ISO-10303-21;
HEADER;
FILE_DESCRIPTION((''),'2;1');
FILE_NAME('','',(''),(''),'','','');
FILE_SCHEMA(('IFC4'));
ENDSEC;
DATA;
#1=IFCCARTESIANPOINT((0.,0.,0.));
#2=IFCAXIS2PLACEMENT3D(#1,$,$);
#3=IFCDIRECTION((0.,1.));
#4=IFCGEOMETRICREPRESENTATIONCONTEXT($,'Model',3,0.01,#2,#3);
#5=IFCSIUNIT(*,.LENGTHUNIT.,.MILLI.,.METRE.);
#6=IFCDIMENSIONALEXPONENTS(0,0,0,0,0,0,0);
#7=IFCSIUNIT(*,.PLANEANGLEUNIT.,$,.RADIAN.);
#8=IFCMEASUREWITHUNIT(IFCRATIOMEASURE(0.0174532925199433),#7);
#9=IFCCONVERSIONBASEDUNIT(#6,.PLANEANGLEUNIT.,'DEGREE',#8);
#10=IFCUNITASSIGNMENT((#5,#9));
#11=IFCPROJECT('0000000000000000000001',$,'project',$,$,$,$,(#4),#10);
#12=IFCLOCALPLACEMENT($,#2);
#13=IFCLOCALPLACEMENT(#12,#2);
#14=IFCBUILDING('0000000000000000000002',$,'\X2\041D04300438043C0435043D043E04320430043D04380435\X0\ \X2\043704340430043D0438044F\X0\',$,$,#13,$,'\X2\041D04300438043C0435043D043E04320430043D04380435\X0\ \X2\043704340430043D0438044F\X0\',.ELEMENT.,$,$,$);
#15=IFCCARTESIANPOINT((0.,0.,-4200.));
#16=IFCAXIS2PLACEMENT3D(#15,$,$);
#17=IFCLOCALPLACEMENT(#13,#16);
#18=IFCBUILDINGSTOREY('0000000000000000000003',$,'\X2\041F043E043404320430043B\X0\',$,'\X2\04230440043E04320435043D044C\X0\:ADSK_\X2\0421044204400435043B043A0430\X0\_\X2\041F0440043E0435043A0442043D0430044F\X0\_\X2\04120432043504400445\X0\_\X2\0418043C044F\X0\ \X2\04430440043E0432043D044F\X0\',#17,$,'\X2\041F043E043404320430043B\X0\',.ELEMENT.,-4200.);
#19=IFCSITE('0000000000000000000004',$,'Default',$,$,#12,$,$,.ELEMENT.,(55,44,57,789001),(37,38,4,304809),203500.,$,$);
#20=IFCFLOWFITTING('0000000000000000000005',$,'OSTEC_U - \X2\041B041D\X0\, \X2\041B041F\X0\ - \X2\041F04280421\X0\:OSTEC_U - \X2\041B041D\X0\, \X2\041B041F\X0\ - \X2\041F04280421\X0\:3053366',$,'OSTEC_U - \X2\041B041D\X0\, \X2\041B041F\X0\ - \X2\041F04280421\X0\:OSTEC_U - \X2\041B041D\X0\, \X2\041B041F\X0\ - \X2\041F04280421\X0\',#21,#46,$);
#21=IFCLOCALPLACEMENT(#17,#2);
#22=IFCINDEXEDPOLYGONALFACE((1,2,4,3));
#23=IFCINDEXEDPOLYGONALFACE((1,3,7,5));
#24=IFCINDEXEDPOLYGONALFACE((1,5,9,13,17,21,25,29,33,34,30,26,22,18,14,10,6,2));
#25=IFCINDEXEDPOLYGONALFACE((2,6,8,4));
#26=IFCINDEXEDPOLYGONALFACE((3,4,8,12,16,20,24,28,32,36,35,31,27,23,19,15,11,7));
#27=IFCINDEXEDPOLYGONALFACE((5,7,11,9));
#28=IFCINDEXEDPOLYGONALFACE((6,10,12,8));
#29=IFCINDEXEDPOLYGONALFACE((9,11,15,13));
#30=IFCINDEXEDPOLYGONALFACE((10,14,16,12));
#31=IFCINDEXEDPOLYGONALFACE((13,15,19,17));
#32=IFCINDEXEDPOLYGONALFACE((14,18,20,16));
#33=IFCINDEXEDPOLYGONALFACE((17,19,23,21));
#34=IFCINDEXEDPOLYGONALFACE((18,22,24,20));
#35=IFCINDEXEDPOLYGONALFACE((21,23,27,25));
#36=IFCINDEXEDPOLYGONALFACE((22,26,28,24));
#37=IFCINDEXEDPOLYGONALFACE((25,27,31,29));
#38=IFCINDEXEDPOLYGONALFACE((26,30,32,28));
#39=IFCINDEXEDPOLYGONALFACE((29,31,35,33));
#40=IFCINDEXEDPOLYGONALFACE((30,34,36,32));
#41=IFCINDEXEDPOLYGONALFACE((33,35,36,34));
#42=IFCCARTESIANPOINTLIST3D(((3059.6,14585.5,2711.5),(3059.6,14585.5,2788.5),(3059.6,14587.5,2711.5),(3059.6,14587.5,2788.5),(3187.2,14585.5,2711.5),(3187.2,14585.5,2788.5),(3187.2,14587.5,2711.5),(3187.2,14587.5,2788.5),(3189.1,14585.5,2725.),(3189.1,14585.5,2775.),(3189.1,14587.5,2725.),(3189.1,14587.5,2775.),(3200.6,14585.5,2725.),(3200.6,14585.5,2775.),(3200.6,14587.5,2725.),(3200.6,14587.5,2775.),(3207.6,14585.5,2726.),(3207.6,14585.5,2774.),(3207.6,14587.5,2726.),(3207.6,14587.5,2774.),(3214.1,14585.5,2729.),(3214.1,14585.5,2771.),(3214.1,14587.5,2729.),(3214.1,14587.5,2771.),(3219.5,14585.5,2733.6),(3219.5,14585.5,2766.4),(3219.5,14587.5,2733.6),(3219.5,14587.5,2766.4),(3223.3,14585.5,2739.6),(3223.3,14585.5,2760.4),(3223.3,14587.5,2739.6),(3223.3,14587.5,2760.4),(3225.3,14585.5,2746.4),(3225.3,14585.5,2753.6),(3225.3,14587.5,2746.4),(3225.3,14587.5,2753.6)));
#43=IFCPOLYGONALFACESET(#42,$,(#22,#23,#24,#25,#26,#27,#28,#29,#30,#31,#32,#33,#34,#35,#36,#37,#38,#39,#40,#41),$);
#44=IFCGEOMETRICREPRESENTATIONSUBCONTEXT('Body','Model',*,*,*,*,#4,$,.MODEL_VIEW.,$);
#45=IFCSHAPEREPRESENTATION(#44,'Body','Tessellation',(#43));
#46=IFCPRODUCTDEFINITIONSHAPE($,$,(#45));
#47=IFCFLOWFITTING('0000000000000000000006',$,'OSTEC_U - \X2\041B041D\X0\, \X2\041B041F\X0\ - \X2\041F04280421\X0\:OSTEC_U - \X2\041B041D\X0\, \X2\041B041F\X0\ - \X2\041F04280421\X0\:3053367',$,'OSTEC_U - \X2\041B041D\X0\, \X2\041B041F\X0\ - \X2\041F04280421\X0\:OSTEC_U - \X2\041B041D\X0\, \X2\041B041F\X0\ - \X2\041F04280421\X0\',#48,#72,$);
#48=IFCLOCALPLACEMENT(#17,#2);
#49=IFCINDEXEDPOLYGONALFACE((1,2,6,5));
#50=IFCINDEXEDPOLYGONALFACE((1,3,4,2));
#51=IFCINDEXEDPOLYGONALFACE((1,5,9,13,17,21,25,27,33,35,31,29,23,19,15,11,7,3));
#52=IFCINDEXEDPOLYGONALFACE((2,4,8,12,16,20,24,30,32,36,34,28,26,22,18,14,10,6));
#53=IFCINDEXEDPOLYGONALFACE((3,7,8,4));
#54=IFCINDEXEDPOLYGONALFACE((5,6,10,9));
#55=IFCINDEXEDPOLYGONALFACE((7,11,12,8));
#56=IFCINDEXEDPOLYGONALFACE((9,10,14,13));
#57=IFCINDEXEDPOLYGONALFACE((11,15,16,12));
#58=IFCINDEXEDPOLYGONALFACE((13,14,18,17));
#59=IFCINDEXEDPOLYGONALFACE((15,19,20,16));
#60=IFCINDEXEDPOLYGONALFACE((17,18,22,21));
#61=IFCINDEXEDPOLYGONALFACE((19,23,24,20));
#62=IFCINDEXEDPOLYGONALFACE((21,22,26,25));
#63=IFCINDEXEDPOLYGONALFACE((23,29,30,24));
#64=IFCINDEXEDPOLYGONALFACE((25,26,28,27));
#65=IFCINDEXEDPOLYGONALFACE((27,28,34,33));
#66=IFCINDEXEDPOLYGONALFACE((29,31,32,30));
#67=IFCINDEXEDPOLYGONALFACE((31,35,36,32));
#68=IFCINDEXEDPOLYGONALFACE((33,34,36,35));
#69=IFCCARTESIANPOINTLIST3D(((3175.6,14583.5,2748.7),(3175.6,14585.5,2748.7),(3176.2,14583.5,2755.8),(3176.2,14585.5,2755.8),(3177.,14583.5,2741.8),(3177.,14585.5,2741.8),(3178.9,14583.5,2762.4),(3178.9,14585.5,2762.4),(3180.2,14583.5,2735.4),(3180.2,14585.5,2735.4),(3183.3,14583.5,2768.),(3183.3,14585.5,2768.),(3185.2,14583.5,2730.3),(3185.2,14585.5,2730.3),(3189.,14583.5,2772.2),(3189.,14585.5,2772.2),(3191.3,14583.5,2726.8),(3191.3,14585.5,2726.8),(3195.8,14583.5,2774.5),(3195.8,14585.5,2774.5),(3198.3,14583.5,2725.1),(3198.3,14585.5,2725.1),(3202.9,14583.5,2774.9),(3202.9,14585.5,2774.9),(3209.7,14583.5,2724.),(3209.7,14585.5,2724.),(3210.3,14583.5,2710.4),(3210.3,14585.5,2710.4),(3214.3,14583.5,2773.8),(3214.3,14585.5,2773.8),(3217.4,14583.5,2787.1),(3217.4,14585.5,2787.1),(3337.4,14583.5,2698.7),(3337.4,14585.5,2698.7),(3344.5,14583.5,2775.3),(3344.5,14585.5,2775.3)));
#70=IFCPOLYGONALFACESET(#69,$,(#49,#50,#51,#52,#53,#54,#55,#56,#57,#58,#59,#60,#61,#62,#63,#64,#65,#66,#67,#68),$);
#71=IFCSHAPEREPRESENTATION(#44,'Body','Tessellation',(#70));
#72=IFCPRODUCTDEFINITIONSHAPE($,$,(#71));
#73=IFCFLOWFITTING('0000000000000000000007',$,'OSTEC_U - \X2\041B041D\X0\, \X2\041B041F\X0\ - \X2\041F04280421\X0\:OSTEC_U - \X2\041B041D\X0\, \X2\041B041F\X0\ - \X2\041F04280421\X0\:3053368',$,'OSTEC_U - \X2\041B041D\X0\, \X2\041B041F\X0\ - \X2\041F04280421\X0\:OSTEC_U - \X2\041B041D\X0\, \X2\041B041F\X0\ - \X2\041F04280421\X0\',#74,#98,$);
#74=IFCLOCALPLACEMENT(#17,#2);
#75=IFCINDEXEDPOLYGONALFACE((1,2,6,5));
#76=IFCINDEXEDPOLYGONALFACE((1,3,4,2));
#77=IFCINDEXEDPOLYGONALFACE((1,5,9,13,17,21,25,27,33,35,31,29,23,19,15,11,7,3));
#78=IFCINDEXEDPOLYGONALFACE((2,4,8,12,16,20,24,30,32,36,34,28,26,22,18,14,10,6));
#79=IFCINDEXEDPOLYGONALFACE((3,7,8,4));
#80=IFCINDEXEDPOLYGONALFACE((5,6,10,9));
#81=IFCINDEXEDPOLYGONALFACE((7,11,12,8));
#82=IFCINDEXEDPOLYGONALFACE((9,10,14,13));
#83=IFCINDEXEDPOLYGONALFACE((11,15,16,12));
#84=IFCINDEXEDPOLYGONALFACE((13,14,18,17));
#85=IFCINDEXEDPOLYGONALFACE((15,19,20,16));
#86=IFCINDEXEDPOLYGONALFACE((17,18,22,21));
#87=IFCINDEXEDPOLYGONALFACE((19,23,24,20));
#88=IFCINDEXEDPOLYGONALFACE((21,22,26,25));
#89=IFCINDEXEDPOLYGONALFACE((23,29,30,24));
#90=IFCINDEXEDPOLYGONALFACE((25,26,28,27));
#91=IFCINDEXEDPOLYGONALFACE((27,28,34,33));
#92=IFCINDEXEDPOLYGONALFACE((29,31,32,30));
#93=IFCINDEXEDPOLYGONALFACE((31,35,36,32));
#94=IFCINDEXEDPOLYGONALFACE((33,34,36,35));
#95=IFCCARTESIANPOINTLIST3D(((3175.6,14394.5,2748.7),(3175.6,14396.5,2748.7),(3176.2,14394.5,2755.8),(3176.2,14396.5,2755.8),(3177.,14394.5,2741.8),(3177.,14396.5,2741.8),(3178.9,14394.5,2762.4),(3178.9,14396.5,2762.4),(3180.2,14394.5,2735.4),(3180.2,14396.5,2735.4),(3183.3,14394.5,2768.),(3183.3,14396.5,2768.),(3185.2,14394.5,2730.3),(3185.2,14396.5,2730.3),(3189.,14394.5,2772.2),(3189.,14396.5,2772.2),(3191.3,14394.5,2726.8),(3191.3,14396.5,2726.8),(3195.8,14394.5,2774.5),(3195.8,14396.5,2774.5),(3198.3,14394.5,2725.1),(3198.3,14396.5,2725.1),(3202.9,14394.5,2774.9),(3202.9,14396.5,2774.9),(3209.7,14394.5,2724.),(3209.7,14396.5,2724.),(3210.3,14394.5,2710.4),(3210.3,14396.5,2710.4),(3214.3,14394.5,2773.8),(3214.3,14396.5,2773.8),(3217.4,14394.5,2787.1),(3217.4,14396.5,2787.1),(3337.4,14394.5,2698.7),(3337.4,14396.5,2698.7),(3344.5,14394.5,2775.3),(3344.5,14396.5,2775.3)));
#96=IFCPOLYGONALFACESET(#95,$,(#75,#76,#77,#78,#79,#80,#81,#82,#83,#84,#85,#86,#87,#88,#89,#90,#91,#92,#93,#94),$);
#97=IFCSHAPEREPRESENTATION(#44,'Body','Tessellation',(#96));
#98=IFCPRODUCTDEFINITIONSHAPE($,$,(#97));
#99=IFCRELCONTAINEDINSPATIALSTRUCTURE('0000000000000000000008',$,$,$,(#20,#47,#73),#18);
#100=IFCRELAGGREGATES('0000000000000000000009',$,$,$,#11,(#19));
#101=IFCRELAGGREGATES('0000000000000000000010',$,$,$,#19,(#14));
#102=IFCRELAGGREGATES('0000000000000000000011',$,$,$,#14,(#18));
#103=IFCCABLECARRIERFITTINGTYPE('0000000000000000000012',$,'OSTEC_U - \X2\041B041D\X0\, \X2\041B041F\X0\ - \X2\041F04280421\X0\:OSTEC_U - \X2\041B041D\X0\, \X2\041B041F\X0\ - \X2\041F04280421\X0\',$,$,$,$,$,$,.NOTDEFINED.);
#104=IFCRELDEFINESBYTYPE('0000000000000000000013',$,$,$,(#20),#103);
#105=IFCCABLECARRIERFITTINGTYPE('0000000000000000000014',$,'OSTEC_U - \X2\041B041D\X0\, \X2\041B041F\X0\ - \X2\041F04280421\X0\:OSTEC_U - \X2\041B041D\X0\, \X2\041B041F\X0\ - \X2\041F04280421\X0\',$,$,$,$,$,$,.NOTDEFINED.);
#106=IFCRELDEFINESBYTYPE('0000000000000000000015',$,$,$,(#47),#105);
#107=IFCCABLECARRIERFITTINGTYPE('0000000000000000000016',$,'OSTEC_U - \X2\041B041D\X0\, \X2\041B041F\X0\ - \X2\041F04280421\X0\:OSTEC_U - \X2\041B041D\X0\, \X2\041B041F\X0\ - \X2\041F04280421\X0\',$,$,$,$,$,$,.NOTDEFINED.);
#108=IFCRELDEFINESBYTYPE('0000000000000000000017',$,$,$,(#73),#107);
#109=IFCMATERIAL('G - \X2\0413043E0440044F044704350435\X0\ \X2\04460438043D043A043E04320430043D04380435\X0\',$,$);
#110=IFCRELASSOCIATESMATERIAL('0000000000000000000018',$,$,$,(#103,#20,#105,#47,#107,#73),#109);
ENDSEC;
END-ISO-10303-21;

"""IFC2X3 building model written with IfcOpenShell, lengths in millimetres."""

from ifc_helpers import new_model, entity, si_unit, converted_unit, direction, frame, frame_2d, origin, place, context, subcontext, project, spatial, polyline, circle_curve, parameter, trimmed, segment, composite_curve, outline, extrude, source, transform, mapped, material, type_object, type_shapes, element, save


model = new_model("IFC2X3")

# Units and contexts
model_context = context("Model", 3, precision=0.01, world=origin(), true_north=direction((0.0, 1.0)))
body_context = subcontext(model_context, "Body", "Model", "MODEL_VIEW")
ifc_project = project(units=[si_unit("LENGTHUNIT", "METRE", prefix="MILLI"), converted_unit("PLANEANGLEUNIT", "DEGREE", entity("IfcRatioMeasure", 0.0174532925199433), si_unit("PLANEANGLEUNIT", "RADIAN"), dimensions=[0, 0, 0, 0, 0, 0, 0])], contexts=[model_context])

# Site, building, storey
site_placement = place(None, frame((0.0, 0.0, 0.0)))
site = spatial("IfcSite", under=ifc_project, at=site_placement, Name="Default", CompositionType="ELEMENT", RefLatitude=(55, 44, 57, 789001), RefLongitude=(37, 38, 4, 304809), RefElevation=203500.0)
building_placement = place(site_placement, origin())
building = spatial("IfcBuilding", under=site, at=building_placement, Name="Наименование здания", LongName="Наименование здания", CompositionType="ELEMENT")
storey_placement = place(building_placement, frame((0.0, 0.0, -4200.0)))
storey = spatial("IfcBuildingStorey", under=building, at=storey_placement, Name="Подвал", ObjectType="Уровень:ADSK_Стрелка_Проектная_Вверх_Имя уровня", LongName="Подвал", CompositionType="ELEMENT", Elevation=-4200.0)

# Flow fittings
ifc_material_1 = material(Name="G - Горячее цинкование")
cable_carrier_fitting_type_1 = type_object("IfcCableCarrierFittingType", Name="OSTEC_U - ЛН, ЛП - ПШС:OSTEC_U - ЛН, ЛП - ПШС", PredefinedType="NOTDEFINED", material=ifc_material_1)
shared_shape_1 = source(origin(), body_context, "Body", "SweptSolid", [
    extrude(outline(composite_curve([segment(trimmed(circle_curve(frame_2d((-41.5, 0.0), x_axis=(1.0, 0.0)), 25.0), [parameter(90.0)], [parameter(270.0)], True, "PARAMETER"), True, "CONTINUOUS"), segment(polyline([(-41.5, -25.0), (-30.0, -25.0)]), True, "CONTINUOUS"), segment(polyline([(-30.0, -25.0), (-28.1, -38.5)]), True, "CONTINUOUS"), segment(polyline([(-28.1, -38.5), (99.5, -38.5)]), True, "CONTINUOUS"), segment(polyline([(99.5, -38.5), (99.5, 38.5)]), True, "CONTINUOUS"), segment(polyline([(99.5, 38.5), (-28.1, 38.5)]), True, "CONTINUOUS"), segment(polyline([(-28.1, 38.5), (-30.0, 25.0)]), True, "CONTINUOUS"), segment(polyline([(-30.0, 25.0), (-41.5, 25.0)]), True, "CONTINUOUS")], self_intersect=False)), frame((41.5, 0.0, 0.0)), (0.0, 0.0, 1.0), 2.0),
])
type_shapes(cable_carrier_fitting_type_1, [shared_shape_1])
flow_fitting_1_placement = place(storey_placement, frame((3200.6, 14585.5, 2750.0), z_axis=(0.0, 1.0, 0.0), x_axis=(-1.0, 0.0, 0.0)))
element("IfcFlowFitting", 1, at=flow_fitting_1_placement, inside=storey, type_object=cable_carrier_fitting_type_1, material=ifc_material_1, Name="OSTEC_U - ЛН, ЛП - ПШС:OSTEC_U - ЛН, ЛП - ПШС:3053366", ObjectType="OSTEC_U - ЛН, ЛП - ПШС:OSTEC_U - ЛН, ЛП - ПШС", context=body_context, shape_type="MappedRepresentation", body=[
    mapped(shared_shape_1, transform((0.0, 0.0, 0.0), scale=1.0)),
])
cable_carrier_fitting_type_2 = type_object("IfcCableCarrierFittingType", Name="OSTEC_U - ЛН, ЛП - ПШС:OSTEC_U - ЛН, ЛП - ПШС", PredefinedType="NOTDEFINED", material=ifc_material_1)
shared_shape_2 = source(origin(), body_context, "Body", "SweptSolid", [
    extrude(outline(composite_curve([segment(trimmed(circle_curve(frame_2d((-41.5, 0.0), x_axis=(1.0, 0.0)), 25.0), [parameter(90.0)], [parameter(270.0)], True, "PARAMETER"), True, "CONTINUOUS"), segment(polyline([(-41.5, -25.0), (-30.0, -25.0)]), True, "CONTINUOUS"), segment(polyline([(-30.0, -25.0), (-28.1, -38.5)]), True, "CONTINUOUS"), segment(polyline([(-28.1, -38.5), (99.5, -38.5)]), True, "CONTINUOUS"), segment(polyline([(99.5, -38.5), (99.5, 38.5)]), True, "CONTINUOUS"), segment(polyline([(99.5, 38.5), (-28.1, 38.5)]), True, "CONTINUOUS"), segment(polyline([(-28.1, 38.5), (-30.0, 25.0)]), True, "CONTINUOUS"), segment(polyline([(-30.0, 25.0), (-41.5, 25.0)]), True, "CONTINUOUS")], self_intersect=False)), frame((41.5, 0.0, 0.0), z_axis=(0.0, 0.0, -1.0), x_axis=(1.0, 0.0, 0.0)), (0.0, 0.0, -1.0), 2.0),
])
type_shapes(cable_carrier_fitting_type_2, [shared_shape_2])
flow_fitting_2_placement = place(storey_placement, frame((3200.6, 14583.5, 2750.0), z_axis=(0.0, 1.0, 0.0), x_axis=(0.995742, 0.0, -0.092183)))
element("IfcFlowFitting", 2, at=flow_fitting_2_placement, inside=storey, type_object=cable_carrier_fitting_type_2, material=ifc_material_1, Name="OSTEC_U - ЛН, ЛП - ПШС:OSTEC_U - ЛН, ЛП - ПШС:3053367", ObjectType="OSTEC_U - ЛН, ЛП - ПШС:OSTEC_U - ЛН, ЛП - ПШС", context=body_context, shape_type="MappedRepresentation", body=[
    mapped(shared_shape_2, transform((0.0, 0.0, 0.0), scale=1.0)),
])
cable_carrier_fitting_type_3 = type_object("IfcCableCarrierFittingType", Name="OSTEC_U - ЛН, ЛП - ПШС:OSTEC_U - ЛН, ЛП - ПШС", PredefinedType="NOTDEFINED", material=ifc_material_1)
shared_shape_3 = source(origin(), body_context, "Body", "SweptSolid", [
    extrude(outline(composite_curve([segment(trimmed(circle_curve(frame_2d((-41.5, 0.0), x_axis=(1.0, 0.0)), 25.0), [parameter(90.0)], [parameter(270.0)], True, "PARAMETER"), True, "CONTINUOUS"), segment(polyline([(-41.5, -25.0), (-30.0, -25.0)]), True, "CONTINUOUS"), segment(polyline([(-30.0, -25.0), (-28.1, -38.5)]), True, "CONTINUOUS"), segment(polyline([(-28.1, -38.5), (99.5, -38.5)]), True, "CONTINUOUS"), segment(polyline([(99.5, -38.5), (99.5, 38.5)]), True, "CONTINUOUS"), segment(polyline([(99.5, 38.5), (-28.1, 38.5)]), True, "CONTINUOUS"), segment(polyline([(-28.1, 38.5), (-30.0, 25.0)]), True, "CONTINUOUS"), segment(polyline([(-30.0, 25.0), (-41.5, 25.0)]), True, "CONTINUOUS")], self_intersect=False)), frame((41.5, 0.0, 0.0)), (0.0, 0.0, 1.0), 2.0),
])
type_shapes(cable_carrier_fitting_type_3, [shared_shape_3])
flow_fitting_3_placement = place(storey_placement, frame((3200.6, 14396.5, 2750.0), z_axis=(0.0, -1.0, 0.0), x_axis=(0.995742, 0.0, -0.092183)))
element("IfcFlowFitting", 3, at=flow_fitting_3_placement, inside=storey, type_object=cable_carrier_fitting_type_3, material=ifc_material_1, Name="OSTEC_U - ЛН, ЛП - ПШС:OSTEC_U - ЛН, ЛП - ПШС:3053368", ObjectType="OSTEC_U - ЛН, ЛП - ПШС:OSTEC_U - ЛН, ЛП - ПШС", context=body_context, shape_type="MappedRepresentation", body=[
    mapped(shared_shape_3, transform((0.0, 0.0, 0.0), scale=1.0)),
])

save(model, "model.ifc")
